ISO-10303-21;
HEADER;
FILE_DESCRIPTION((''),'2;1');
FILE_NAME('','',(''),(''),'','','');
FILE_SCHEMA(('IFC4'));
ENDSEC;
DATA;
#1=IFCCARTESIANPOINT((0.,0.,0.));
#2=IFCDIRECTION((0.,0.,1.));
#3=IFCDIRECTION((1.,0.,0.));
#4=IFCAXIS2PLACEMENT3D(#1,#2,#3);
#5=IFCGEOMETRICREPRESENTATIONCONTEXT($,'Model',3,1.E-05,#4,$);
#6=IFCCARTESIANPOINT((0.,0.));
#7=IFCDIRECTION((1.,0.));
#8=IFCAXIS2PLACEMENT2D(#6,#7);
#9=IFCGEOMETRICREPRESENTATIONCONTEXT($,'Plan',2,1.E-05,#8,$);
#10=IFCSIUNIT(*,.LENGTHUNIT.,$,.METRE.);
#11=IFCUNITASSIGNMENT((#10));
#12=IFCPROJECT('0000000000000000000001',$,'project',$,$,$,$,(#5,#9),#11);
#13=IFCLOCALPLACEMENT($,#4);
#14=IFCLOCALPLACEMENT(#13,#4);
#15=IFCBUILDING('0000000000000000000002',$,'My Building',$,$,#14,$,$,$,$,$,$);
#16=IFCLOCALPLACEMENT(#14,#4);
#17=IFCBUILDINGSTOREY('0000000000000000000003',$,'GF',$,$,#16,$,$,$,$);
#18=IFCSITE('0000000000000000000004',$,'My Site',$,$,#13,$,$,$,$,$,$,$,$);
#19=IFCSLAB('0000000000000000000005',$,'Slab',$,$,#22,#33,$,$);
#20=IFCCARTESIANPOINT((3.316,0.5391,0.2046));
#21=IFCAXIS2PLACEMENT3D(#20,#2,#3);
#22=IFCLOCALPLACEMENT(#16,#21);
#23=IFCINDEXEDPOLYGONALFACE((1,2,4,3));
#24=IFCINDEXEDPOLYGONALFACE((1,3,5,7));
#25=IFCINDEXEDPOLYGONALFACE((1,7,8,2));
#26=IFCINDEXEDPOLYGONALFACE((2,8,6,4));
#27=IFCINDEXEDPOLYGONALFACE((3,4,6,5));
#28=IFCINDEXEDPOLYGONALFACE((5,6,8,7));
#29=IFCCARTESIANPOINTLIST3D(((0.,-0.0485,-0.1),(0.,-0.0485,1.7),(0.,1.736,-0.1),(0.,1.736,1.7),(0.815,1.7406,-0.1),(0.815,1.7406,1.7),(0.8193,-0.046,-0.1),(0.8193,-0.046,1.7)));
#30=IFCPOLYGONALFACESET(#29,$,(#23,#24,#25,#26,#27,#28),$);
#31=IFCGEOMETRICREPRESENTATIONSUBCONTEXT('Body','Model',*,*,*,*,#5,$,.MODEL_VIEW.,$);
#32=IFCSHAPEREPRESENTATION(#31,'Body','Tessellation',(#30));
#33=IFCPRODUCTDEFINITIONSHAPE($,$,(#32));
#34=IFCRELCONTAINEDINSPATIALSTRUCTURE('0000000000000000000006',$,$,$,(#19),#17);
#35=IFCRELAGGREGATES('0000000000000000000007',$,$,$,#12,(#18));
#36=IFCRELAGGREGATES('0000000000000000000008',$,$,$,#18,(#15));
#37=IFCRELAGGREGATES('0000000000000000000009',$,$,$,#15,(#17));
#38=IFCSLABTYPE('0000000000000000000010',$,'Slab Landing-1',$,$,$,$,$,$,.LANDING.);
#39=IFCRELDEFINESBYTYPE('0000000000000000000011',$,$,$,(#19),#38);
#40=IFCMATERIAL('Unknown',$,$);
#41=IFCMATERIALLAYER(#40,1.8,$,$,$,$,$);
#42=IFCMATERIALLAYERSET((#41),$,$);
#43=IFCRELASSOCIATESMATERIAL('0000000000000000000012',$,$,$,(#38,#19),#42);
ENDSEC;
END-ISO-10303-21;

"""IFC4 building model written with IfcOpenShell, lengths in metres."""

from ifc_helpers import new_model, si_unit, frame, origin_with_axes, origin_2d_with_axis, place, context, subcontext, project, spatial, indexed_curve, outline, extrude, material, layer, layer_set, layer_usage, type_object, element, save


model = new_model("IFC4")

# Units and contexts
model_context = context("Model", 3, precision=1e-05, world=origin_with_axes())
plan_context = context("Plan", 2, precision=1e-05, world=origin_2d_with_axis())
body_context_1 = subcontext(model_context, "Body", "Model", "MODEL_VIEW")
ifc_project = project(units=[si_unit("LENGTHUNIT", "METRE")], contexts=[model_context, plan_context])

# Site, building, storey
site_placement = place(None, origin_with_axes())
site = spatial("IfcSite", under=ifc_project, at=site_placement, Name="My Site")
building_placement = place(site_placement, origin_with_axes())
building = spatial("IfcBuilding", under=site, at=building_placement, Name="My Building")
storey_placement = place(building_placement, origin_with_axes())
storey = spatial("IfcBuildingStorey", under=building, at=storey_placement, Name="GF")

# Shared definitions
ifc_material = material(Name="Unknown")

# Slab
ifc_layer_1 = layer(ifc_material, 1.8)
ifc_layer_set_1 = layer_set([ifc_layer_1])
ifc_layer_usage_1 = layer_usage(ifc_layer_set_1, "AXIS3", "POSITIVE", -0.1)
slab_type_1 = type_object("IfcSlabType", Name="Slab Landing-1", PredefinedType="LANDING", material=ifc_layer_set_1)
slab_1_placement = place(storey_placement, frame((3.316, 0.5391, 0.2046), z_axis=(0.0, 0.0, 1.0), x_axis=(1.0, 0.0, 0.0)))
element("IfcSlab", 1, at=slab_1_placement, inside=storey, type_object=slab_type_1, material=ifc_layer_usage_1, Name="Slab", context=body_context_1, shape_type="SweptSolid", body=[
    extrude(outline(indexed_curve([(0.0, -0.0485), (0.0, 1.736), (0.815, 1.7406), (0.8193, -0.046), (0.0, -0.0485)])), frame((0.0, 0.0, -0.1), z_axis=(0.0, 0.0, 1.0), x_axis=(1.0, 0.0, 0.0)), (0.0, 0.0, 1.0), 1.8),
])

save(model, "model.ifc")
